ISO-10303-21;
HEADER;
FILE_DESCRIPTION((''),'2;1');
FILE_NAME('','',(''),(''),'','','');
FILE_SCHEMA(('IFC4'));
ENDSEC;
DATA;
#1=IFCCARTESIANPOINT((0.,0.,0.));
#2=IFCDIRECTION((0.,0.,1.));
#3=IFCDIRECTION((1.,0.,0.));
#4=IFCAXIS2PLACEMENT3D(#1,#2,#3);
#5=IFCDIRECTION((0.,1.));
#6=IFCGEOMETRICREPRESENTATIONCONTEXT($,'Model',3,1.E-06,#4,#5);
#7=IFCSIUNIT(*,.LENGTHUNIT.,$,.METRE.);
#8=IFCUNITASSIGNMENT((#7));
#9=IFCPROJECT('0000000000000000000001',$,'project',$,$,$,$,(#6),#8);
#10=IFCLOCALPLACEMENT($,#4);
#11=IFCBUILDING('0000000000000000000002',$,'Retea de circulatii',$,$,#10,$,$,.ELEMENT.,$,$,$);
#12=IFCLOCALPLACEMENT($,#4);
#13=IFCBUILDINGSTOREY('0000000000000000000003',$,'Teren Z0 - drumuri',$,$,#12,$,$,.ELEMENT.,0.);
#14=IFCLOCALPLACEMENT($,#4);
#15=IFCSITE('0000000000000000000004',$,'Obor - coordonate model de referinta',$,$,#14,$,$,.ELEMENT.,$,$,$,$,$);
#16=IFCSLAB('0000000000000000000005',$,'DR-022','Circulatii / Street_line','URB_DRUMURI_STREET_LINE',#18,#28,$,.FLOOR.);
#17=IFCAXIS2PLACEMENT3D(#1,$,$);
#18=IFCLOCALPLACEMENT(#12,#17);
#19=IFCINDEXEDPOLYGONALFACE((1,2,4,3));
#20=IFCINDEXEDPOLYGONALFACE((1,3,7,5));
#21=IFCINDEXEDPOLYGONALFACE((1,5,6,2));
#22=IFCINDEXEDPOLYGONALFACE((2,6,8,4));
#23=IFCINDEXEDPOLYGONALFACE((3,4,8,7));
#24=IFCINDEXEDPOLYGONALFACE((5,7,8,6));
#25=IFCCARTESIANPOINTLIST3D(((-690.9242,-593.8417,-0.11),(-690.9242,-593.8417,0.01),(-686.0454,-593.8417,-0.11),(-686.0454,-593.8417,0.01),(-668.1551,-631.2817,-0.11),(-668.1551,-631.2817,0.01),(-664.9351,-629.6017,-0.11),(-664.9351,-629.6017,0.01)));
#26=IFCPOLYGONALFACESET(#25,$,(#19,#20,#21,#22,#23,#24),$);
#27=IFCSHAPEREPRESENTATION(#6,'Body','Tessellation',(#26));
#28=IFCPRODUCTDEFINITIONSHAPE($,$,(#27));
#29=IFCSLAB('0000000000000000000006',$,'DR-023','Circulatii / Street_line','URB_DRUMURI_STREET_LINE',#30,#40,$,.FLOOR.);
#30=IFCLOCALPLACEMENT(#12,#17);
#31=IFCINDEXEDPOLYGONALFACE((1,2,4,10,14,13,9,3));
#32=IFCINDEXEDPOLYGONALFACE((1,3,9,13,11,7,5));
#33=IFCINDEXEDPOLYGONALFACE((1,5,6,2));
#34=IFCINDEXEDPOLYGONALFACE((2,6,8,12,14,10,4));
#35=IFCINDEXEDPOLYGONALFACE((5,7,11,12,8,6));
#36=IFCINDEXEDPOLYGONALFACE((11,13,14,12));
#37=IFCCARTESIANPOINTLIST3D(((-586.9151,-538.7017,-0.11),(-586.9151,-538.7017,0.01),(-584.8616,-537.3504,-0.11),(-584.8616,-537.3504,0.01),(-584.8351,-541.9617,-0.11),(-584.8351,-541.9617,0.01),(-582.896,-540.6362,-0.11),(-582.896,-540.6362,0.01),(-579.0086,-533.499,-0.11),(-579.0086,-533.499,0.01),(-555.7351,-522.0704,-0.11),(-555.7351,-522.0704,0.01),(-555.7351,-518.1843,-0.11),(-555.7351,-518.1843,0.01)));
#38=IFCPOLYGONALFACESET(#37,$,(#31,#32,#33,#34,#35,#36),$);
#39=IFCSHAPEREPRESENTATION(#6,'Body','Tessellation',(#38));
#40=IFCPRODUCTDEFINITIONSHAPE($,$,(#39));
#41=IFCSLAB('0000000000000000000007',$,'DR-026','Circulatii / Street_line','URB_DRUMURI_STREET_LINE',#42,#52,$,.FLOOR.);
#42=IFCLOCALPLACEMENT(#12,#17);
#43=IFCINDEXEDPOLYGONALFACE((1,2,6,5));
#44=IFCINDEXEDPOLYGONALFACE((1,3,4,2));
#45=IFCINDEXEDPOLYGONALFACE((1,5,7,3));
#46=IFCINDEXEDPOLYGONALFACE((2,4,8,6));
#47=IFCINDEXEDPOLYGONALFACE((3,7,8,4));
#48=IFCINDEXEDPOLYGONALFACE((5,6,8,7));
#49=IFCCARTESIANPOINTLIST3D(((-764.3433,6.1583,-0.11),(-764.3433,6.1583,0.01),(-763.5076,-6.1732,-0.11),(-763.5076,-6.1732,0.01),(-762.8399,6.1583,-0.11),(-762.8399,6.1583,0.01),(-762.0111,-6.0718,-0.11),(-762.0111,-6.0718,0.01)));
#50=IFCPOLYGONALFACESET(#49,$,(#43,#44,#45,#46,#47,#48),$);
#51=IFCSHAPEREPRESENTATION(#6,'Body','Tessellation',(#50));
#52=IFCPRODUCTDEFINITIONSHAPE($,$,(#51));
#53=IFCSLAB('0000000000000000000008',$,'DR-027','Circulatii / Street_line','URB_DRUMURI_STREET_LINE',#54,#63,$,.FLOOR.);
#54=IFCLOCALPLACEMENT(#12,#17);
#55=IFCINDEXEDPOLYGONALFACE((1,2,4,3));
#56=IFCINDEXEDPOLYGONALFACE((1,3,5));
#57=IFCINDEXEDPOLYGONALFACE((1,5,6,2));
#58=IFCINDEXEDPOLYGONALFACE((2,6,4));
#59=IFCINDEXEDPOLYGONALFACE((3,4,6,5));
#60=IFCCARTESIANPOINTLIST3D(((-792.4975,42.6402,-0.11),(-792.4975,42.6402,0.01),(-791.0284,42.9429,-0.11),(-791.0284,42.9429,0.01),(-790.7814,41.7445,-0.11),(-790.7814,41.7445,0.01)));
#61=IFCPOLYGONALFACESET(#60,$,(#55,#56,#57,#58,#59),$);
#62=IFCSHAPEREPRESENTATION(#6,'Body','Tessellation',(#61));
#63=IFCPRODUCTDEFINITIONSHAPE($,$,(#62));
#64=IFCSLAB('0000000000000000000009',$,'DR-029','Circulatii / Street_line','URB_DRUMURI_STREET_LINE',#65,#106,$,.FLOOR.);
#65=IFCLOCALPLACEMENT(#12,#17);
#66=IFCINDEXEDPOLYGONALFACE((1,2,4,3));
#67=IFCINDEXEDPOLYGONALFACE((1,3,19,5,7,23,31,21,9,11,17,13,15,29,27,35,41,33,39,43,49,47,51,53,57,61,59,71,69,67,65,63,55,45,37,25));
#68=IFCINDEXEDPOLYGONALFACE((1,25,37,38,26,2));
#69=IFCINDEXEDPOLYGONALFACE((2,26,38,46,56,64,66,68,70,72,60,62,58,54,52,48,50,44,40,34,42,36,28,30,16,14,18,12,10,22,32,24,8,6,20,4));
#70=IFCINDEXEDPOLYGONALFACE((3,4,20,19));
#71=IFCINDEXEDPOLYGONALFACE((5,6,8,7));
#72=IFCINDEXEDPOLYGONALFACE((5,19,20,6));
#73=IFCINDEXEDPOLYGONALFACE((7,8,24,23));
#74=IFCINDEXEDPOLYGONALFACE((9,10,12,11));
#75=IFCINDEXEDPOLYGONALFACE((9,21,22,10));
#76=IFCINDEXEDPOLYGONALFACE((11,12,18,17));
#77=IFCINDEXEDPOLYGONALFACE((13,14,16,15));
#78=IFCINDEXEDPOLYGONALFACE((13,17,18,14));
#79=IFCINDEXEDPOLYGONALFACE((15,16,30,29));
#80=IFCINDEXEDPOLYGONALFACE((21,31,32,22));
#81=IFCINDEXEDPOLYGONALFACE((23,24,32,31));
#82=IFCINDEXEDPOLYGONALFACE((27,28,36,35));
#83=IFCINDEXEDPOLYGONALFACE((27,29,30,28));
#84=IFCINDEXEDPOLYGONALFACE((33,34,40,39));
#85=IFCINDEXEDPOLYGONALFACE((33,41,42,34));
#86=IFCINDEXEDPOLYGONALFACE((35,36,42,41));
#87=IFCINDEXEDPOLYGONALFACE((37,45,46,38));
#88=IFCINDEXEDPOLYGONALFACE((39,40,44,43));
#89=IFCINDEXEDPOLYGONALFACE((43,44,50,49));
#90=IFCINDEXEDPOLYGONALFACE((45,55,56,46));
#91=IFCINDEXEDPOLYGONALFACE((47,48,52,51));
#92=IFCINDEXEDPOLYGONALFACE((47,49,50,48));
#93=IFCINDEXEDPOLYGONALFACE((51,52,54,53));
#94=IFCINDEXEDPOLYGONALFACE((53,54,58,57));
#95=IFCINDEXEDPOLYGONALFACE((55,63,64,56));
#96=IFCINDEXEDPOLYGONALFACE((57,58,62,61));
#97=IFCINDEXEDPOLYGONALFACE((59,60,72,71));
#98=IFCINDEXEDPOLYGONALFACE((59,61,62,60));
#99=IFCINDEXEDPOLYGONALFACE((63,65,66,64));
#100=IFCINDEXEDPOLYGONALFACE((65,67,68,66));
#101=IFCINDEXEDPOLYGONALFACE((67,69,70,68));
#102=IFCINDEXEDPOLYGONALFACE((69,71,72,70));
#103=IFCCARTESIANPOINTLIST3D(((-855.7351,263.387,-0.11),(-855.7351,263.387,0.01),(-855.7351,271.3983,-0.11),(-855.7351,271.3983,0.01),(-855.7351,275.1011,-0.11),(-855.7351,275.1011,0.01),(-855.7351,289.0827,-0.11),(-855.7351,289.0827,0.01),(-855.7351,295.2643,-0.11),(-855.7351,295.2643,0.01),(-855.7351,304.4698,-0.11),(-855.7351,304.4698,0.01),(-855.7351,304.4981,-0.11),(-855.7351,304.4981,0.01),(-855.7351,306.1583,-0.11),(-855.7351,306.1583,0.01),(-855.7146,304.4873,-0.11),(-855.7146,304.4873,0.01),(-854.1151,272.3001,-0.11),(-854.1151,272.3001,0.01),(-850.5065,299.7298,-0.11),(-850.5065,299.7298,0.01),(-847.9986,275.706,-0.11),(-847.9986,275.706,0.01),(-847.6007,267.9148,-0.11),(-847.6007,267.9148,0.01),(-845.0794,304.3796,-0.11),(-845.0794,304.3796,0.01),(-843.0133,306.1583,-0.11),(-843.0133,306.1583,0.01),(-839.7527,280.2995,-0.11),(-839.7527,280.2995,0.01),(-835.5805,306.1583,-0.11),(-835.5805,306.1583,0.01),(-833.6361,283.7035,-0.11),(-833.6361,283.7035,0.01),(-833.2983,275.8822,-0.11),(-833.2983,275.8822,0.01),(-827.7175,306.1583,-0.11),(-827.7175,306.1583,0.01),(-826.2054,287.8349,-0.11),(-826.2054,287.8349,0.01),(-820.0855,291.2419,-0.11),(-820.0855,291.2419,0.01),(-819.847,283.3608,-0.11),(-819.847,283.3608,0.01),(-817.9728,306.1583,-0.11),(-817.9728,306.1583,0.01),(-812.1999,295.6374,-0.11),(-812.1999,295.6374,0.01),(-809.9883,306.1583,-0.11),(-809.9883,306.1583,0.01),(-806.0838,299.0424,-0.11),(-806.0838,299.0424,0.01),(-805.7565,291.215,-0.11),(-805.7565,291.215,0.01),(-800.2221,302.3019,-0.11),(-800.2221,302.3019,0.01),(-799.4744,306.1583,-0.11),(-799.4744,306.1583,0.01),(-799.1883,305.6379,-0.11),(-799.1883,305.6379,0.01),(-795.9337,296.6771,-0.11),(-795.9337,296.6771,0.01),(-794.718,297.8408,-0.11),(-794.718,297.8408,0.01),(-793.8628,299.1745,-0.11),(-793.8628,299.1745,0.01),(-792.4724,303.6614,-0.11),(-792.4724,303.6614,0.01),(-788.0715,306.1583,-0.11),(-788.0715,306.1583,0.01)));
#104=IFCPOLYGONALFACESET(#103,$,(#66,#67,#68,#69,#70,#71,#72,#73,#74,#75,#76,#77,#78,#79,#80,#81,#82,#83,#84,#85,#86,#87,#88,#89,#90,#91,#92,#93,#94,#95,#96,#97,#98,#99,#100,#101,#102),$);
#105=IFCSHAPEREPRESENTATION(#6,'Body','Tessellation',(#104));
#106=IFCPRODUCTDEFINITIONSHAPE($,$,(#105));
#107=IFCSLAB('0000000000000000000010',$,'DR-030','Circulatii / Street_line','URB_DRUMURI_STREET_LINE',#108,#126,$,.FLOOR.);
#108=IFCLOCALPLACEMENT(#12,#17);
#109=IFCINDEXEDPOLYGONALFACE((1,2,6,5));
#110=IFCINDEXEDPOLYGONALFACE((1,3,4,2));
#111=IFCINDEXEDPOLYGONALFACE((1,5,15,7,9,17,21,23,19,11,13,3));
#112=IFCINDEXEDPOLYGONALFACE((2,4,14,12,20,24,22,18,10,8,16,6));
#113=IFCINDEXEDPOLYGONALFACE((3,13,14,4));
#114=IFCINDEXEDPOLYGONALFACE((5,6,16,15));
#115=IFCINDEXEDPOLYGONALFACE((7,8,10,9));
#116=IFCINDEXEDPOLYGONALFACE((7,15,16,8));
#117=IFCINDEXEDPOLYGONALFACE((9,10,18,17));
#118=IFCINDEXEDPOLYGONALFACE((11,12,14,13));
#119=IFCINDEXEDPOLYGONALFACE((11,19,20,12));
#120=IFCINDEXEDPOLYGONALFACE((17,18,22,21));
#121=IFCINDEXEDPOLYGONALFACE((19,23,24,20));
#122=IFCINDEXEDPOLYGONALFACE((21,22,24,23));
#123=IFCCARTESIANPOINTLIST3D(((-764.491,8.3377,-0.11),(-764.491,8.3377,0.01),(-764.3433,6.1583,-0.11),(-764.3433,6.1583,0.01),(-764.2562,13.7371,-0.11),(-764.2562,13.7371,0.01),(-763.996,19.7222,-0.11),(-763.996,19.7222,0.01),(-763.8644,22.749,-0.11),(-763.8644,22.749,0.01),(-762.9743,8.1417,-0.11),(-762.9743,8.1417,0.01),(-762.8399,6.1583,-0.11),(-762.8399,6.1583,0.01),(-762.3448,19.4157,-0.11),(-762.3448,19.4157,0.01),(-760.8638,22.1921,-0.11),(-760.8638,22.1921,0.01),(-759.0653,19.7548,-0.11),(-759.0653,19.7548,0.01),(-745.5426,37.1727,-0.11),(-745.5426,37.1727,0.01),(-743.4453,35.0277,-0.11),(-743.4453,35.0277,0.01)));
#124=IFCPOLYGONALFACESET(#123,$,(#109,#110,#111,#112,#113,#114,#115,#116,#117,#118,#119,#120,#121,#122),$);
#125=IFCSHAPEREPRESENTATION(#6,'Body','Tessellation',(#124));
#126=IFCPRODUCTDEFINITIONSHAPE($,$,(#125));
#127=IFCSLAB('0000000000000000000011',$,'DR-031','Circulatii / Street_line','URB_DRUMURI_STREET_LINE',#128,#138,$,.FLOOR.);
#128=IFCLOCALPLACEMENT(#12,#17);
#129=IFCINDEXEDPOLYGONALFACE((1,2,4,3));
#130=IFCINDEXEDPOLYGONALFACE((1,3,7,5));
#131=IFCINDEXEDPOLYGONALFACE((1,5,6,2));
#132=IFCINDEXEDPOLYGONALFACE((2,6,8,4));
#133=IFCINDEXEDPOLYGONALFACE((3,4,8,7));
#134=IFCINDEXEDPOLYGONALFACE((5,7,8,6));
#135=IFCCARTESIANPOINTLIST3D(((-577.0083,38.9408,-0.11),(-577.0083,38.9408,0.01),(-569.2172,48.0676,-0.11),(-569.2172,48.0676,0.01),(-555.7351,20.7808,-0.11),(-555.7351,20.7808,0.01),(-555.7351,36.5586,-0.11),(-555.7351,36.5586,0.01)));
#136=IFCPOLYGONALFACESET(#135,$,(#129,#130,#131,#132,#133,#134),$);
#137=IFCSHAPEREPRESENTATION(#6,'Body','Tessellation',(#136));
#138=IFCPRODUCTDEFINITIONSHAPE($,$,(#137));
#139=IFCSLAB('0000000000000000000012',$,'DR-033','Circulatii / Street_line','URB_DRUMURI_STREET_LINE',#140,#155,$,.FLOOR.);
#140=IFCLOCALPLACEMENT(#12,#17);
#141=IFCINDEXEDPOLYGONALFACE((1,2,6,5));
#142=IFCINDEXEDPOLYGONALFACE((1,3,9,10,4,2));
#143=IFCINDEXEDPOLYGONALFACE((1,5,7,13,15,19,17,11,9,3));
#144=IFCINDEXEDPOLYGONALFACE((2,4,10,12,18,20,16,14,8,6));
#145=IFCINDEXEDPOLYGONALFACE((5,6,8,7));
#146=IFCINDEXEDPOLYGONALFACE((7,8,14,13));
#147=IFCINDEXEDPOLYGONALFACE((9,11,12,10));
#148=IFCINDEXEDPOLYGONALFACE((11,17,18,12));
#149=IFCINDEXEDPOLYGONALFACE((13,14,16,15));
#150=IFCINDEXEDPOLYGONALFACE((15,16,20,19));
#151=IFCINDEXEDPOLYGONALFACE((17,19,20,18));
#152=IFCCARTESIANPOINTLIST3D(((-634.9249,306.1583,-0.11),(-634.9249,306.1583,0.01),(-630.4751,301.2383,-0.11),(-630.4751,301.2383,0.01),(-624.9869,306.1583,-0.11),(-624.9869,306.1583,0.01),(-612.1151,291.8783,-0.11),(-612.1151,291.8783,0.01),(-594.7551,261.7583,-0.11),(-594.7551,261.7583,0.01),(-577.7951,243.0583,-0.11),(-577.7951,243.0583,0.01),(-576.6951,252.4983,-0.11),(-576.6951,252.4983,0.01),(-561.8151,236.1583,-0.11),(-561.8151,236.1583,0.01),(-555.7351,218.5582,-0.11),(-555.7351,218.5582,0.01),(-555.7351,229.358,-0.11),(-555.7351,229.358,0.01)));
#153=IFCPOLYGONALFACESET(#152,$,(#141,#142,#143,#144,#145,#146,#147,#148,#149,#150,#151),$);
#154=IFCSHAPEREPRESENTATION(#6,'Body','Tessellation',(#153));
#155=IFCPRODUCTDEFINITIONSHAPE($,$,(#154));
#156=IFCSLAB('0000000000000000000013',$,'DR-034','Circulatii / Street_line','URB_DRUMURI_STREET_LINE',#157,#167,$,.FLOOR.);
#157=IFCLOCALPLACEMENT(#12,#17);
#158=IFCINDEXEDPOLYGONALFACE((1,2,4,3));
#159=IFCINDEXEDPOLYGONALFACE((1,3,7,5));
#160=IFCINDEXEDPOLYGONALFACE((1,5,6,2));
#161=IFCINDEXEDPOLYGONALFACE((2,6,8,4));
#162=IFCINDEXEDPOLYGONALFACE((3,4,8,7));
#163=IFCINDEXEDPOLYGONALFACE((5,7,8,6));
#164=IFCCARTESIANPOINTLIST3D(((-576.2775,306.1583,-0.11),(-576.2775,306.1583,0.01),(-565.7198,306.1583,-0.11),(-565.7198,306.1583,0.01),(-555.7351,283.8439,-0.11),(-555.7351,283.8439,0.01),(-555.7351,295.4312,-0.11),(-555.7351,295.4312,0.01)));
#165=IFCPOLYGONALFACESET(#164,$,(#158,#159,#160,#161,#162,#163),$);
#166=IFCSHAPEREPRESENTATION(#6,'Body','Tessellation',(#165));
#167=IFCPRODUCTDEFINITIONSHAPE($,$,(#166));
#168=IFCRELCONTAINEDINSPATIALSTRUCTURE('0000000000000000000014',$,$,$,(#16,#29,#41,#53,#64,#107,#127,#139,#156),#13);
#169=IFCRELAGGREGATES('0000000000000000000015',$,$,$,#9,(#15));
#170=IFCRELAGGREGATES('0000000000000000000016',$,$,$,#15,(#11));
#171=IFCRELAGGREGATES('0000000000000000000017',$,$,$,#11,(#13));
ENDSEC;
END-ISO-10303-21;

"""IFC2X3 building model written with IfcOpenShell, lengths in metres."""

from ifc_helpers import new_model, si_unit, direction, frame, origin_with_axes, place, context, project, spatial, polyline, outline, extrude, element, save


model = new_model("IFC2X3")

# Units and contexts
model_context = context("Model", 3, precision=1e-06, world=origin_with_axes(), true_north=direction((0.0, 1.0)))
ifc_project = project(units=[si_unit("LENGTHUNIT", "METRE")], contexts=[model_context])

# Site, building, storey
site_placement = place(None, origin_with_axes())
site = spatial("IfcSite", under=ifc_project, at=site_placement, Name="Obor - coordonate model de referinta", CompositionType="ELEMENT")
building_placement = place(None, origin_with_axes())
building = spatial("IfcBuilding", under=site, at=building_placement, Name="Retea de circulatii", CompositionType="ELEMENT")
storey_placement = place(None, origin_with_axes())
storey = spatial("IfcBuildingStorey", under=building, at=storey_placement, Name="Teren Z0 - drumuri", CompositionType="ELEMENT", Elevation=0.0)

# Slabs
slab_1_placement = place(None, origin_with_axes())
element("IfcSlab", 1, at=slab_1_placement, inside=storey, Name="DR-022", Description="Circulatii / Street_line", ObjectType="URB_DRUMURI_STREET_LINE", PredefinedType="FLOOR", context=model_context, shape_type="SweptSolid", body=[
    extrude(outline(polyline([(-690.9242, -593.8417), (-668.1551, -631.2817), (-664.9351, -629.6017), (-686.0454, -593.8417), (-690.9242, -593.8417)])), frame((0.0, 0.0, -0.11), z_axis=(0.0, 0.0, 1.0), x_axis=(1.0, 0.0, 0.0)), (0.0, 0.0, 1.0), 0.12),
])
slab_2_placement = place(None, origin_with_axes())
element("IfcSlab", 2, at=slab_2_placement, inside=storey, Name="DR-023", Description="Circulatii / Street_line", ObjectType="URB_DRUMURI_STREET_LINE", PredefinedType="FLOOR", context=model_context, shape_type="SweptSolid", body=[
    extrude(outline(polyline([(-584.8351, -541.9617), (-582.896, -540.6362), (-555.7351, -522.0704), (-555.7351, -518.1843), (-579.0086, -533.499), (-584.8616, -537.3504), (-586.9151, -538.7017), (-584.8351, -541.9617)])), frame((0.0, 0.0, -0.11), z_axis=(0.0, 0.0, 1.0), x_axis=(1.0, 0.0, 0.0)), (0.0, 0.0, 1.0), 0.12),
])
slab_3_placement = place(None, origin_with_axes())
element("IfcSlab", 3, at=slab_3_placement, inside=storey, Name="DR-026", Description="Circulatii / Street_line", ObjectType="URB_DRUMURI_STREET_LINE", PredefinedType="FLOOR", context=model_context, shape_type="SweptSolid", body=[
    extrude(outline(polyline([(-762.8399, 6.1583), (-764.3433, 6.1583), (-763.5076, -6.1732), (-762.0111, -6.0718), (-762.8399, 6.1583)])), frame((0.0, 0.0, -0.11), z_axis=(0.0, 0.0, 1.0), x_axis=(1.0, 0.0, 0.0)), (0.0, 0.0, 1.0), 0.12),
])
slab_4_placement = place(None, origin_with_axes())
element("IfcSlab", 4, at=slab_4_placement, inside=storey, Name="DR-027", Description="Circulatii / Street_line", ObjectType="URB_DRUMURI_STREET_LINE", PredefinedType="FLOOR", context=model_context, shape_type="SweptSolid", body=[
    extrude(outline(polyline([(-790.7814, 41.7445), (-791.0284, 42.9429), (-792.4975, 42.6402), (-790.7814, 41.7445)])), frame((0.0, 0.0, -0.11), z_axis=(0.0, 0.0, 1.0), x_axis=(1.0, 0.0, 0.0)), (0.0, 0.0, 1.0), 0.12),
])
slab_5_placement = place(None, origin_with_axes())
element("IfcSlab", 5, at=slab_5_placement, inside=storey, Name="DR-029", Description="Circulatii / Street_line", ObjectType="URB_DRUMURI_STREET_LINE", PredefinedType="FLOOR", context=model_context, shape_type="SweptSolid", body=[
    extrude(outline(polyline([(-795.9337, 296.6771), (-794.718, 297.8408), (-793.8628, 299.1745), (-792.4724, 303.6614), (-788.0715, 306.1583), (-799.4744, 306.1583), (-799.1883, 305.6379), (-800.2221, 302.3019), (-806.0838, 299.0424), (-809.9883, 306.1583), (-817.9728, 306.1583), (-812.1999, 295.6374), (-820.0855, 291.2419), (-827.7175, 306.1583), (-835.5805, 306.1583), (-826.2054, 287.8349), (-833.6361, 283.7035), (-845.0794, 304.3796), (-843.0133, 306.1583), (-855.7351, 306.1583), (-855.7351, 304.4981), (-855.7146, 304.4873), (-855.7351, 304.4698), (-855.7351, 295.2643), (-850.5065, 299.7298), (-839.7527, 280.2995), (-847.9986, 275.706), (-855.7351, 289.0827), (-855.7351, 275.1011), (-854.1151, 272.3001), (-855.7351, 271.3983), (-855.7351, 263.387), (-847.6007, 267.9148), (-833.2983, 275.8822), (-819.847, 283.3608), (-805.7565, 291.215), (-795.9337, 296.6771)])), frame((0.0, 0.0, -0.11), z_axis=(0.0, 0.0, 1.0), x_axis=(1.0, 0.0, 0.0)), (0.0, 0.0, 1.0), 0.12),
])
slab_6_placement = place(None, origin_with_axes())
element("IfcSlab", 6, at=slab_6_placement, inside=storey, Name="DR-030", Description="Circulatii / Street_line", ObjectType="URB_DRUMURI_STREET_LINE", PredefinedType="FLOOR", context=model_context, shape_type="SweptSolid", body=[
    extrude(outline(polyline([(-763.8644, 22.749), (-763.996, 19.7222), (-762.3448, 19.4157), (-764.2562, 13.7371), (-764.491, 8.3377), (-764.3433, 6.1583), (-762.8399, 6.1583), (-762.9743, 8.1417), (-759.0653, 19.7548), (-743.4453, 35.0277), (-745.5426, 37.1727), (-760.8638, 22.1921), (-763.8644, 22.749)])), frame((0.0, 0.0, -0.11), z_axis=(0.0, 0.0, 1.0), x_axis=(1.0, 0.0, 0.0)), (0.0, 0.0, 1.0), 0.12),
])
slab_7_placement = place(None, origin_with_axes())
element("IfcSlab", 7, at=slab_7_placement, inside=storey, Name="DR-031", Description="Circulatii / Street_line", ObjectType="URB_DRUMURI_STREET_LINE", PredefinedType="FLOOR", context=model_context, shape_type="SweptSolid", body=[
    extrude(outline(polyline([(-577.0083, 38.9408), (-555.7351, 20.7808), (-555.7351, 36.5586), (-569.2172, 48.0676), (-577.0083, 38.9408)])), frame((0.0, 0.0, -0.11), z_axis=(0.0, 0.0, 1.0), x_axis=(1.0, 0.0, 0.0)), (0.0, 0.0, 1.0), 0.12),
])
slab_8_placement = place(None, origin_with_axes())
element("IfcSlab", 8, at=slab_8_placement, inside=storey, Name="DR-033", Description="Circulatii / Street_line", ObjectType="URB_DRUMURI_STREET_LINE", PredefinedType="FLOOR", context=model_context, shape_type="SweptSolid", body=[
    extrude(outline(polyline([(-624.9869, 306.1583), (-634.9249, 306.1583), (-630.4751, 301.2383), (-594.7551, 261.7583), (-577.7951, 243.0583), (-555.7351, 218.5582), (-555.7351, 229.358), (-561.8151, 236.1583), (-576.6951, 252.4983), (-612.1151, 291.8783), (-624.9869, 306.1583)])), frame((0.0, 0.0, -0.11), z_axis=(0.0, 0.0, 1.0), x_axis=(1.0, 0.0, 0.0)), (0.0, 0.0, 1.0), 0.12),
])
slab_9_placement = place(None, origin_with_axes())
element("IfcSlab", 9, at=slab_9_placement, inside=storey, Name="DR-034", Description="Circulatii / Street_line", ObjectType="URB_DRUMURI_STREET_LINE", PredefinedType="FLOOR", context=model_context, shape_type="SweptSolid", body=[
    extrude(outline(polyline([(-576.2775, 306.1583), (-555.7351, 283.8439), (-555.7351, 295.4312), (-565.7198, 306.1583), (-576.2775, 306.1583)])), frame((0.0, 0.0, -0.11), z_axis=(0.0, 0.0, 1.0), x_axis=(1.0, 0.0, 0.0)), (0.0, 0.0, 1.0), 0.12),
])

save(model, "model.ifc")
